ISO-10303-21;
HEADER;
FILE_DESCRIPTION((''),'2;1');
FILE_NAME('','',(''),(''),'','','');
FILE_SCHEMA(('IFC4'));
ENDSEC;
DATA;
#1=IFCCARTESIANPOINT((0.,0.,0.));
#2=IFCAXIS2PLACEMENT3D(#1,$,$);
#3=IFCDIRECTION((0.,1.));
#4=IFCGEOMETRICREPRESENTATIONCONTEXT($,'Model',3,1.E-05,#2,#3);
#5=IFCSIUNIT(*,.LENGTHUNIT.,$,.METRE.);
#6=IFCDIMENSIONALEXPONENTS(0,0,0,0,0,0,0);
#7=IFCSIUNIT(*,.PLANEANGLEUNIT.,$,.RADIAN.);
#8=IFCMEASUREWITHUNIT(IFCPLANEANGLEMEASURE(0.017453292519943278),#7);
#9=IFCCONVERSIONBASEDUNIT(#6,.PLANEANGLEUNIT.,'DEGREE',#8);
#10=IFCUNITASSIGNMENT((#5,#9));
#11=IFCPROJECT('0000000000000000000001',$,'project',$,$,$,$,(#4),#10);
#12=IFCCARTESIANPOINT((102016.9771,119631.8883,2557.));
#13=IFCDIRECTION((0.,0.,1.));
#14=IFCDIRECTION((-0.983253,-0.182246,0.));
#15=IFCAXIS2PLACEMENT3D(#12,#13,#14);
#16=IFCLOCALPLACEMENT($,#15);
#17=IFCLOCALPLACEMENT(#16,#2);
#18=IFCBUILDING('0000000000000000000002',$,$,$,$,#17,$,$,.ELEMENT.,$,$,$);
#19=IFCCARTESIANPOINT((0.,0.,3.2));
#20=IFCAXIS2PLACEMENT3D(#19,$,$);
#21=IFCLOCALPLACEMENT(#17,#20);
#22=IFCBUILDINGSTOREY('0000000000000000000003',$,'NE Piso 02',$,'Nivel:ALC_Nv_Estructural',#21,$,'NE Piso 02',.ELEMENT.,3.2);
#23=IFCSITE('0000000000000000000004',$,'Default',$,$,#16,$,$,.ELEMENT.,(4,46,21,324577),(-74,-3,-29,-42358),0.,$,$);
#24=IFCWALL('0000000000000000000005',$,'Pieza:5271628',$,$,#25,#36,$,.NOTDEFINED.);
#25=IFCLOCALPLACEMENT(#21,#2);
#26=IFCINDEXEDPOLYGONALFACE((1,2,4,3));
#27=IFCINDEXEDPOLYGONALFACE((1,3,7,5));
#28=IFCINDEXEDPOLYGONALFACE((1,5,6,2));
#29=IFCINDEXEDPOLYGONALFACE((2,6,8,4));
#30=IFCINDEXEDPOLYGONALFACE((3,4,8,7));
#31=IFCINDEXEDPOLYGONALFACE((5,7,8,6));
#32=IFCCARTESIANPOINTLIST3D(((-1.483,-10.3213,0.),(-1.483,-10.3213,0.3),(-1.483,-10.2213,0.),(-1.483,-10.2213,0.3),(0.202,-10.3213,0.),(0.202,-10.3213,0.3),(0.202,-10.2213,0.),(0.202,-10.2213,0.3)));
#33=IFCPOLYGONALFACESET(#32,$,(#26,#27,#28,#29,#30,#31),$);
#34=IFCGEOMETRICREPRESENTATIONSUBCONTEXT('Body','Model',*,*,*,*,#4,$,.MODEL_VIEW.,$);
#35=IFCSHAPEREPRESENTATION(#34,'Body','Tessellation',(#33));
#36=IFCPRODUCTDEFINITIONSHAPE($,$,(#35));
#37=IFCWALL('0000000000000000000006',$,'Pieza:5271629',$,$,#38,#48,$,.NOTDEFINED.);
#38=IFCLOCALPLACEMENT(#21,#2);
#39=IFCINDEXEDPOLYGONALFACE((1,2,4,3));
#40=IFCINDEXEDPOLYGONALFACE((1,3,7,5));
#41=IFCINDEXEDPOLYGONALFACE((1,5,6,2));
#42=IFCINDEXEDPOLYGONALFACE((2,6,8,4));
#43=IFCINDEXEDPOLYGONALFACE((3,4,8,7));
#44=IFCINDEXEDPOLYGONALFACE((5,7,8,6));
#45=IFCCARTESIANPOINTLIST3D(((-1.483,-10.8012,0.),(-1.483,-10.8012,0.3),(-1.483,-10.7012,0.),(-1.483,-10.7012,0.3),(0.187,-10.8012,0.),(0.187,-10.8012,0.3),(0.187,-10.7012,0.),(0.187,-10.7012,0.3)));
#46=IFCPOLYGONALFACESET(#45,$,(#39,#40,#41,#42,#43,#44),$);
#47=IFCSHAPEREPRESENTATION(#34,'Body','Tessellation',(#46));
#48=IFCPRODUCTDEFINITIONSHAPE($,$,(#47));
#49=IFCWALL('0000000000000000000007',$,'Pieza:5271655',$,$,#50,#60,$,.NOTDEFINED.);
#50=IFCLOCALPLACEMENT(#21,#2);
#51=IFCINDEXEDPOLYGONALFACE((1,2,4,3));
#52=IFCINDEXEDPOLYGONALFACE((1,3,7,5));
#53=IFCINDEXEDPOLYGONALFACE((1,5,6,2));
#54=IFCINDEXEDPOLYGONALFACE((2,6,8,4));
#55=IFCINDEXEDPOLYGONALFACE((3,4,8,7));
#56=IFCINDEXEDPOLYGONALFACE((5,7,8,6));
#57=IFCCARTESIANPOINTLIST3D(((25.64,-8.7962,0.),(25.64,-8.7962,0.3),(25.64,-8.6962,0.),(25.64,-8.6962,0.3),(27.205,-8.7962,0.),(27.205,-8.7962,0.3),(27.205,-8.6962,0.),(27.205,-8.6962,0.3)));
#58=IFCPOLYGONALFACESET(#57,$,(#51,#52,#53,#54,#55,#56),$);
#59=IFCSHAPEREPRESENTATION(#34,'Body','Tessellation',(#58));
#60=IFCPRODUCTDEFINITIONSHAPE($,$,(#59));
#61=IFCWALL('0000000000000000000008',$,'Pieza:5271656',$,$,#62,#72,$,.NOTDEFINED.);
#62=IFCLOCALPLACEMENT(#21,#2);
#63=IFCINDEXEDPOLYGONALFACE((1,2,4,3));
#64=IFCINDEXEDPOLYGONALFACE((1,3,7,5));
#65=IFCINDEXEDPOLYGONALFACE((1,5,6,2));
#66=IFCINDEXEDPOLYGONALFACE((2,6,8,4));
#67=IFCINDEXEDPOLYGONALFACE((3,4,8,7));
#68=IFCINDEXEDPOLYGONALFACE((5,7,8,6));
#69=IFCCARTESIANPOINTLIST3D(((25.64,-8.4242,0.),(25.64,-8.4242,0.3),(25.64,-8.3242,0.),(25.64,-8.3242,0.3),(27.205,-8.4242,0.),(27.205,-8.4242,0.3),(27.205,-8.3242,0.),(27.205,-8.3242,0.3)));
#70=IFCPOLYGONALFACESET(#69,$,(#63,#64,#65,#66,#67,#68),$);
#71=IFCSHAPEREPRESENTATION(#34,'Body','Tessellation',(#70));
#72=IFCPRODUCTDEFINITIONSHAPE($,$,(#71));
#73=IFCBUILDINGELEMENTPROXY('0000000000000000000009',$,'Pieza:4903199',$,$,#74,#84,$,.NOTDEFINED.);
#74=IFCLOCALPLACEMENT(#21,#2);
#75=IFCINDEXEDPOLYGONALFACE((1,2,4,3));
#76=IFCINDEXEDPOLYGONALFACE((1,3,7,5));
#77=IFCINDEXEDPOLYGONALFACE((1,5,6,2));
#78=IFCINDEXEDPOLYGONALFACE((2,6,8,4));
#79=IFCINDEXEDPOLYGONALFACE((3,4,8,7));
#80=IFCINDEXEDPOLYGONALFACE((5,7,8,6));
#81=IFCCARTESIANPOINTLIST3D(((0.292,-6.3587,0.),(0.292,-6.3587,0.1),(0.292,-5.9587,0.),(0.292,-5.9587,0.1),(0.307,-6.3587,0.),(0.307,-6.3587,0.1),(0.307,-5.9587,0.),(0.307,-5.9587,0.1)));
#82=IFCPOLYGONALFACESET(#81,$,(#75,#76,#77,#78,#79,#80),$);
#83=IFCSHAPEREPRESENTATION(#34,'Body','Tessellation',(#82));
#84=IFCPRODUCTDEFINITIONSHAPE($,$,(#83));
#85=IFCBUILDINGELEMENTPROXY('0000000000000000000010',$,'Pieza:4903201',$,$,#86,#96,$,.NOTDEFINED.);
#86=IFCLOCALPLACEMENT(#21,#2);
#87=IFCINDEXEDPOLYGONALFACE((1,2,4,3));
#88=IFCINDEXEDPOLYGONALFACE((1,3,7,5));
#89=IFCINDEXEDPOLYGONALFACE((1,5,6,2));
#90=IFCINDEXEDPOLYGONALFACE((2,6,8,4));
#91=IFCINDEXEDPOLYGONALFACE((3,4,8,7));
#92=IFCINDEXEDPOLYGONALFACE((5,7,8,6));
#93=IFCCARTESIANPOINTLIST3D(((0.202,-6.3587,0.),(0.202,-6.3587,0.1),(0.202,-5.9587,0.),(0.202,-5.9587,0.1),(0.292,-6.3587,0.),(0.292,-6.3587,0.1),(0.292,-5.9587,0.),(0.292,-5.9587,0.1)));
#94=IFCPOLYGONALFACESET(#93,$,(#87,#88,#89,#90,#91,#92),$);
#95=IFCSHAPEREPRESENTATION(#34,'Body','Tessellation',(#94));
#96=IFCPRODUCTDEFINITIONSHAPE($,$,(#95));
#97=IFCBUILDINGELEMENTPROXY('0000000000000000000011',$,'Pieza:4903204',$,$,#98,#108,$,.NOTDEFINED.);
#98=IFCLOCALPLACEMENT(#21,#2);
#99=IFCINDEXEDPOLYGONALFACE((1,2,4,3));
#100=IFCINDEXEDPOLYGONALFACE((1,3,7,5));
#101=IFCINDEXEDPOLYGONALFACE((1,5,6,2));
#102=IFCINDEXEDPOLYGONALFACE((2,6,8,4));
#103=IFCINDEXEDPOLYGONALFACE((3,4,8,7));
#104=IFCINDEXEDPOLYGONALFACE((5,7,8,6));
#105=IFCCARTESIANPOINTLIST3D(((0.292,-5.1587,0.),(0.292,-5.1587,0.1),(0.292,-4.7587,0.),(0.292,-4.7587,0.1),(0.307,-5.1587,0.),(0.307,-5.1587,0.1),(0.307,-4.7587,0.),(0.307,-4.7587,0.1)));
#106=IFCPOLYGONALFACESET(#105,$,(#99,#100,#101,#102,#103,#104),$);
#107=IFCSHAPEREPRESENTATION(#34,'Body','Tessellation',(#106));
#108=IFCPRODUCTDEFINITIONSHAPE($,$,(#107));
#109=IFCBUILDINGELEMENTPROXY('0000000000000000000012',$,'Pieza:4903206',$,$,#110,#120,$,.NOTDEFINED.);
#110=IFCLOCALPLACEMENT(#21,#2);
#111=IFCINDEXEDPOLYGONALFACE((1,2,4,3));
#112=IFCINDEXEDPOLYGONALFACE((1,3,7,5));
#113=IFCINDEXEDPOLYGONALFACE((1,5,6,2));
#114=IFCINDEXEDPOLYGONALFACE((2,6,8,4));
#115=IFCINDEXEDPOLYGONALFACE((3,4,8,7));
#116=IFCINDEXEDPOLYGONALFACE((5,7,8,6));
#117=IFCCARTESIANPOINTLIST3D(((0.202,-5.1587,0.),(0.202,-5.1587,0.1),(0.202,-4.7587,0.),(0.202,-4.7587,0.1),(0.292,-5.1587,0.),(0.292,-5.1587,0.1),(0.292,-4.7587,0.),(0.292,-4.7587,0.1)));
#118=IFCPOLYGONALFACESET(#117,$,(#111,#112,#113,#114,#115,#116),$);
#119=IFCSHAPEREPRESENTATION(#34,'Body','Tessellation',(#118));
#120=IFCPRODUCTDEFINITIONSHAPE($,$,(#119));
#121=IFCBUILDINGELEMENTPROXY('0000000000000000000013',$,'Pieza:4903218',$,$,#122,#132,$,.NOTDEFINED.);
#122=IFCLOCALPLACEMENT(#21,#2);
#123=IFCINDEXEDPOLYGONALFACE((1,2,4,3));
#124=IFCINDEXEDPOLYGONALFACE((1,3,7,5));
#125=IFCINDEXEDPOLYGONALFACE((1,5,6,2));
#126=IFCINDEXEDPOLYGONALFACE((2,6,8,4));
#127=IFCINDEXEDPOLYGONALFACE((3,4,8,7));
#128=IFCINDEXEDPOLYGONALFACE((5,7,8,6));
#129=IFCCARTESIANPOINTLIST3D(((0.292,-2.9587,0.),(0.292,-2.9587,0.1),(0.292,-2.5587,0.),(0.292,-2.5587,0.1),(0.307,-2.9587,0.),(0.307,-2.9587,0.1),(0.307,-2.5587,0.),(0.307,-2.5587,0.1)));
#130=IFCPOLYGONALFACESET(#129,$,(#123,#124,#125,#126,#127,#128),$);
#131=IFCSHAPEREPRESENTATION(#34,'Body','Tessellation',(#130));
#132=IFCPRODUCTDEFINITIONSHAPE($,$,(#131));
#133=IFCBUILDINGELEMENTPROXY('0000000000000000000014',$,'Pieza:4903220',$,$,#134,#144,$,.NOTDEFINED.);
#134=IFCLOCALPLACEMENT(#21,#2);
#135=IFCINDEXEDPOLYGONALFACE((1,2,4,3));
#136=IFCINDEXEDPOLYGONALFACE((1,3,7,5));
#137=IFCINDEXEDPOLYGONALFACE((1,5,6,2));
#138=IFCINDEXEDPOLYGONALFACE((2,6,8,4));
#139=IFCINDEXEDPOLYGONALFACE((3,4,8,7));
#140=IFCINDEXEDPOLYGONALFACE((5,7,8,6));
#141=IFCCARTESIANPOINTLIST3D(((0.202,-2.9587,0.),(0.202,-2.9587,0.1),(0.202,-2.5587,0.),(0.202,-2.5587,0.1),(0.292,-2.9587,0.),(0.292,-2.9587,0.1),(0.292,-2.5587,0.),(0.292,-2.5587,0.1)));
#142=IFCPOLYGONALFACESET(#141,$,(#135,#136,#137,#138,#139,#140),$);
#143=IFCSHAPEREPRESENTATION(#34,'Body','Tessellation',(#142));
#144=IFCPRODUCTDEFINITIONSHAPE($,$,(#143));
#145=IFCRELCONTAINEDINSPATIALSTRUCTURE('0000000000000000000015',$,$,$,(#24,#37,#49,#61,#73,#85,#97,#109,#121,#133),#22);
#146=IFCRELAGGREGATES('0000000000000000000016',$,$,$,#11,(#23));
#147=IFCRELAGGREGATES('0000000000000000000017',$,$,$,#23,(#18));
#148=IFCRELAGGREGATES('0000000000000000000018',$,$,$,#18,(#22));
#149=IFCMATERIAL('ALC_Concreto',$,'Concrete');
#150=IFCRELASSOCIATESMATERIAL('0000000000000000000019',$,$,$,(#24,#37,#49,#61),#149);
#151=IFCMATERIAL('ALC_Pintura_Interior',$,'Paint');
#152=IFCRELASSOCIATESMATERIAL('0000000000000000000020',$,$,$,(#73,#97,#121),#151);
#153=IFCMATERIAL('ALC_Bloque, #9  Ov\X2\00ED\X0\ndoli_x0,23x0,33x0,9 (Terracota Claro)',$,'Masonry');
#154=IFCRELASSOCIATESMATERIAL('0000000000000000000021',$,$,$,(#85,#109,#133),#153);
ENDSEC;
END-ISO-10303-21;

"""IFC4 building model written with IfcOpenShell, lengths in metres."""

from ifc_helpers import new_model, entity, si_unit, converted_unit, direction, frame, frame_2d, origin, origin_2d_with_axis, place, context, subcontext, project, spatial, rectangle, extrude, material, element, save


model = new_model("IFC4")

# Units and contexts
model_context = context("Model", 3, precision=1e-05, world=origin(), true_north=direction((0.0, 1.0)))
body_context = subcontext(model_context, "Body", "Model", "MODEL_VIEW")
ifc_project = project(units=[si_unit("LENGTHUNIT", "METRE"), converted_unit("PLANEANGLEUNIT", "DEGREE", entity("IfcPlaneAngleMeasure", 0.017453292519943278), si_unit("PLANEANGLEUNIT", "RADIAN"), dimensions=[0, 0, 0, 0, 0, 0, 0])], contexts=[model_context])

# Site, building, storey
site_placement = place(None, frame((102016.9771, 119631.8883, 2557.0), z_axis=(0.0, 0.0, 1.0), x_axis=(-0.983253, -0.182246, 0.0)))
site = spatial("IfcSite", under=ifc_project, at=site_placement, Name="Default", CompositionType="ELEMENT", RefLatitude=(4, 46, 21, 324577), RefLongitude=(-74, -3, -29, -42358), RefElevation=0.0)
building_placement = place(site_placement, origin())
building = spatial("IfcBuilding", under=site, at=building_placement, CompositionType="ELEMENT")
storey_placement = place(building_placement, frame((0.0, 0.0, 3.2)))
storey = spatial("IfcBuildingStorey", under=building, at=storey_placement, Name="NE Piso 02", ObjectType="Nivel:ALC_Nv_Estructural", LongName="NE Piso 02", CompositionType="ELEMENT", Elevation=3.2)

# Walls
ifc_material_1 = material(Name="ALC_Bloque, #9  Ovíndoli_x0,23x0,33x0,9 (Terracota Claro)", Category="Masonry")
ifc_material_2 = material(Name="ALC_Concreto", Category="Concrete")
ifc_material_3 = material(Name="ALC_Pintura_Interior", Category="Paint")
wall_1_placement = place(storey_placement, origin())
element("IfcWall", 1, at=wall_1_placement, inside=storey, material=ifc_material_2, Name="Pieza:5271628", PredefinedType="NOTDEFINED", context=body_context, shape_type="SweptSolid", body=[
    extrude(rectangle(XDim=0.1, YDim=1.685, at=frame_2d((0.0, 0.0), x_axis=(1.0, 0.0))), frame((-0.6405, -10.2713, 0.0), z_axis=(0.0, 0.0, 1.0), x_axis=(0.0, -1.0, 0.0)), (0.0, 0.0, 1.0), 0.3),
])
wall_2_placement = place(storey_placement, origin())
element("IfcWall", 2, at=wall_2_placement, inside=storey, material=ifc_material_2, Name="Pieza:5271629", PredefinedType="NOTDEFINED", context=body_context, shape_type="SweptSolid", body=[
    extrude(rectangle(XDim=0.1, YDim=1.67, at=frame_2d((0.0, 0.0), x_axis=(1.0, 0.0))), frame((-0.648, -10.7512, 0.0), z_axis=(0.0, 0.0, 1.0), x_axis=(0.0, -1.0, 0.0)), (0.0, 0.0, 1.0), 0.3),
])
wall_3_placement = place(storey_placement, origin())
element("IfcWall", 3, at=wall_3_placement, inside=storey, material=ifc_material_2, Name="Pieza:5271655", PredefinedType="NOTDEFINED", context=body_context, shape_type="SweptSolid", body=[
    extrude(rectangle(XDim=0.1, YDim=1.565, at=frame_2d((0.0, 0.0), x_axis=(1.0, 0.0))), frame((26.4225, -8.7462, 0.0), z_axis=(0.0, 0.0, 1.0), x_axis=(0.0, -1.0, 0.0)), (0.0, 0.0, 1.0), 0.3),
])
wall_4_placement = place(storey_placement, origin())
element("IfcWall", 4, at=wall_4_placement, inside=storey, material=ifc_material_2, Name="Pieza:5271656", PredefinedType="NOTDEFINED", context=body_context, shape_type="SweptSolid", body=[
    extrude(rectangle(XDim=0.1, YDim=1.565, at=frame_2d((0.0, 0.0), x_axis=(1.0, 0.0))), frame((26.4225, -8.3742, 0.0), z_axis=(0.0, 0.0, 1.0), x_axis=(0.0, -1.0, 0.0)), (0.0, 0.0, 1.0), 0.3),
])

# Building element proxies
proxy_1_placement = place(storey_placement, origin())
element("IfcBuildingElementProxy", 5, at=proxy_1_placement, inside=storey, material=ifc_material_3, Name="Pieza:4903199", PredefinedType="NOTDEFINED", context=body_context, shape_type="SweptSolid", body=[
    extrude(rectangle(XDim=0.1, YDim=0.4, at=origin_2d_with_axis()), frame((0.292, -6.1587, 0.05), z_axis=(1.0, 0.0, 0.0), x_axis=(0.0, 0.0, -1.0)), (0.0, 0.0, 1.0), 0.015),
])
proxy_2_placement = place(storey_placement, origin())
element("IfcBuildingElementProxy", 6, at=proxy_2_placement, inside=storey, material=ifc_material_1, Name="Pieza:4903201", PredefinedType="NOTDEFINED", context=body_context, shape_type="SweptSolid", body=[
    extrude(rectangle(XDim=0.1, YDim=0.4, at=frame_2d((0.0, 0.0), x_axis=(1.0, 0.0))), frame((0.202, -6.1587, 0.05), z_axis=(1.0, 0.0, 0.0), x_axis=(0.0, 0.0, -1.0)), (0.0, 0.0, 1.0), 0.09),
])
proxy_3_placement = place(storey_placement, origin())
element("IfcBuildingElementProxy", 7, at=proxy_3_placement, inside=storey, material=ifc_material_3, Name="Pieza:4903204", PredefinedType="NOTDEFINED", context=body_context, shape_type="SweptSolid", body=[
    extrude(rectangle(XDim=0.1, YDim=0.4, at=frame_2d((0.0, 0.0), x_axis=(1.0, 0.0))), frame((0.292, -4.9587, 0.05), z_axis=(1.0, 0.0, 0.0), x_axis=(0.0, 0.0, -1.0)), (0.0, 0.0, 1.0), 0.015),
])
proxy_4_placement = place(storey_placement, origin())
element("IfcBuildingElementProxy", 8, at=proxy_4_placement, inside=storey, material=ifc_material_1, Name="Pieza:4903206", PredefinedType="NOTDEFINED", context=body_context, shape_type="SweptSolid", body=[
    extrude(rectangle(XDim=0.1, YDim=0.4, at=frame_2d((0.0, 0.0), x_axis=(1.0, 0.0))), frame((0.202, -4.9587, 0.05), z_axis=(1.0, 0.0, 0.0), x_axis=(0.0, 0.0, -1.0)), (0.0, 0.0, 1.0), 0.09),
])
proxy_5_placement = place(storey_placement, origin())
element("IfcBuildingElementProxy", 9, at=proxy_5_placement, inside=storey, material=ifc_material_3, Name="Pieza:4903218", PredefinedType="NOTDEFINED", context=body_context, shape_type="SweptSolid", body=[
    extrude(rectangle(XDim=0.1, YDim=0.4, at=frame_2d((0.0, 0.0), x_axis=(1.0, 0.0))), frame((0.292, -2.7587, 0.05), z_axis=(1.0, 0.0, 0.0), x_axis=(0.0, 0.0, -1.0)), (0.0, 0.0, 1.0), 0.015),
])
proxy_6_placement = place(storey_placement, origin())
element("IfcBuildingElementProxy", 10, at=proxy_6_placement, inside=storey, material=ifc_material_1, Name="Pieza:4903220", PredefinedType="NOTDEFINED", context=body_context, shape_type="SweptSolid", body=[
    extrude(rectangle(XDim=0.1, YDim=0.4, at=frame_2d((0.0, 0.0), x_axis=(1.0, 0.0))), frame((0.202, -2.7587, 0.05), z_axis=(1.0, 0.0, 0.0), x_axis=(0.0, 0.0, -1.0)), (0.0, 0.0, 1.0), 0.09),
])

save(model, "model.ifc")
